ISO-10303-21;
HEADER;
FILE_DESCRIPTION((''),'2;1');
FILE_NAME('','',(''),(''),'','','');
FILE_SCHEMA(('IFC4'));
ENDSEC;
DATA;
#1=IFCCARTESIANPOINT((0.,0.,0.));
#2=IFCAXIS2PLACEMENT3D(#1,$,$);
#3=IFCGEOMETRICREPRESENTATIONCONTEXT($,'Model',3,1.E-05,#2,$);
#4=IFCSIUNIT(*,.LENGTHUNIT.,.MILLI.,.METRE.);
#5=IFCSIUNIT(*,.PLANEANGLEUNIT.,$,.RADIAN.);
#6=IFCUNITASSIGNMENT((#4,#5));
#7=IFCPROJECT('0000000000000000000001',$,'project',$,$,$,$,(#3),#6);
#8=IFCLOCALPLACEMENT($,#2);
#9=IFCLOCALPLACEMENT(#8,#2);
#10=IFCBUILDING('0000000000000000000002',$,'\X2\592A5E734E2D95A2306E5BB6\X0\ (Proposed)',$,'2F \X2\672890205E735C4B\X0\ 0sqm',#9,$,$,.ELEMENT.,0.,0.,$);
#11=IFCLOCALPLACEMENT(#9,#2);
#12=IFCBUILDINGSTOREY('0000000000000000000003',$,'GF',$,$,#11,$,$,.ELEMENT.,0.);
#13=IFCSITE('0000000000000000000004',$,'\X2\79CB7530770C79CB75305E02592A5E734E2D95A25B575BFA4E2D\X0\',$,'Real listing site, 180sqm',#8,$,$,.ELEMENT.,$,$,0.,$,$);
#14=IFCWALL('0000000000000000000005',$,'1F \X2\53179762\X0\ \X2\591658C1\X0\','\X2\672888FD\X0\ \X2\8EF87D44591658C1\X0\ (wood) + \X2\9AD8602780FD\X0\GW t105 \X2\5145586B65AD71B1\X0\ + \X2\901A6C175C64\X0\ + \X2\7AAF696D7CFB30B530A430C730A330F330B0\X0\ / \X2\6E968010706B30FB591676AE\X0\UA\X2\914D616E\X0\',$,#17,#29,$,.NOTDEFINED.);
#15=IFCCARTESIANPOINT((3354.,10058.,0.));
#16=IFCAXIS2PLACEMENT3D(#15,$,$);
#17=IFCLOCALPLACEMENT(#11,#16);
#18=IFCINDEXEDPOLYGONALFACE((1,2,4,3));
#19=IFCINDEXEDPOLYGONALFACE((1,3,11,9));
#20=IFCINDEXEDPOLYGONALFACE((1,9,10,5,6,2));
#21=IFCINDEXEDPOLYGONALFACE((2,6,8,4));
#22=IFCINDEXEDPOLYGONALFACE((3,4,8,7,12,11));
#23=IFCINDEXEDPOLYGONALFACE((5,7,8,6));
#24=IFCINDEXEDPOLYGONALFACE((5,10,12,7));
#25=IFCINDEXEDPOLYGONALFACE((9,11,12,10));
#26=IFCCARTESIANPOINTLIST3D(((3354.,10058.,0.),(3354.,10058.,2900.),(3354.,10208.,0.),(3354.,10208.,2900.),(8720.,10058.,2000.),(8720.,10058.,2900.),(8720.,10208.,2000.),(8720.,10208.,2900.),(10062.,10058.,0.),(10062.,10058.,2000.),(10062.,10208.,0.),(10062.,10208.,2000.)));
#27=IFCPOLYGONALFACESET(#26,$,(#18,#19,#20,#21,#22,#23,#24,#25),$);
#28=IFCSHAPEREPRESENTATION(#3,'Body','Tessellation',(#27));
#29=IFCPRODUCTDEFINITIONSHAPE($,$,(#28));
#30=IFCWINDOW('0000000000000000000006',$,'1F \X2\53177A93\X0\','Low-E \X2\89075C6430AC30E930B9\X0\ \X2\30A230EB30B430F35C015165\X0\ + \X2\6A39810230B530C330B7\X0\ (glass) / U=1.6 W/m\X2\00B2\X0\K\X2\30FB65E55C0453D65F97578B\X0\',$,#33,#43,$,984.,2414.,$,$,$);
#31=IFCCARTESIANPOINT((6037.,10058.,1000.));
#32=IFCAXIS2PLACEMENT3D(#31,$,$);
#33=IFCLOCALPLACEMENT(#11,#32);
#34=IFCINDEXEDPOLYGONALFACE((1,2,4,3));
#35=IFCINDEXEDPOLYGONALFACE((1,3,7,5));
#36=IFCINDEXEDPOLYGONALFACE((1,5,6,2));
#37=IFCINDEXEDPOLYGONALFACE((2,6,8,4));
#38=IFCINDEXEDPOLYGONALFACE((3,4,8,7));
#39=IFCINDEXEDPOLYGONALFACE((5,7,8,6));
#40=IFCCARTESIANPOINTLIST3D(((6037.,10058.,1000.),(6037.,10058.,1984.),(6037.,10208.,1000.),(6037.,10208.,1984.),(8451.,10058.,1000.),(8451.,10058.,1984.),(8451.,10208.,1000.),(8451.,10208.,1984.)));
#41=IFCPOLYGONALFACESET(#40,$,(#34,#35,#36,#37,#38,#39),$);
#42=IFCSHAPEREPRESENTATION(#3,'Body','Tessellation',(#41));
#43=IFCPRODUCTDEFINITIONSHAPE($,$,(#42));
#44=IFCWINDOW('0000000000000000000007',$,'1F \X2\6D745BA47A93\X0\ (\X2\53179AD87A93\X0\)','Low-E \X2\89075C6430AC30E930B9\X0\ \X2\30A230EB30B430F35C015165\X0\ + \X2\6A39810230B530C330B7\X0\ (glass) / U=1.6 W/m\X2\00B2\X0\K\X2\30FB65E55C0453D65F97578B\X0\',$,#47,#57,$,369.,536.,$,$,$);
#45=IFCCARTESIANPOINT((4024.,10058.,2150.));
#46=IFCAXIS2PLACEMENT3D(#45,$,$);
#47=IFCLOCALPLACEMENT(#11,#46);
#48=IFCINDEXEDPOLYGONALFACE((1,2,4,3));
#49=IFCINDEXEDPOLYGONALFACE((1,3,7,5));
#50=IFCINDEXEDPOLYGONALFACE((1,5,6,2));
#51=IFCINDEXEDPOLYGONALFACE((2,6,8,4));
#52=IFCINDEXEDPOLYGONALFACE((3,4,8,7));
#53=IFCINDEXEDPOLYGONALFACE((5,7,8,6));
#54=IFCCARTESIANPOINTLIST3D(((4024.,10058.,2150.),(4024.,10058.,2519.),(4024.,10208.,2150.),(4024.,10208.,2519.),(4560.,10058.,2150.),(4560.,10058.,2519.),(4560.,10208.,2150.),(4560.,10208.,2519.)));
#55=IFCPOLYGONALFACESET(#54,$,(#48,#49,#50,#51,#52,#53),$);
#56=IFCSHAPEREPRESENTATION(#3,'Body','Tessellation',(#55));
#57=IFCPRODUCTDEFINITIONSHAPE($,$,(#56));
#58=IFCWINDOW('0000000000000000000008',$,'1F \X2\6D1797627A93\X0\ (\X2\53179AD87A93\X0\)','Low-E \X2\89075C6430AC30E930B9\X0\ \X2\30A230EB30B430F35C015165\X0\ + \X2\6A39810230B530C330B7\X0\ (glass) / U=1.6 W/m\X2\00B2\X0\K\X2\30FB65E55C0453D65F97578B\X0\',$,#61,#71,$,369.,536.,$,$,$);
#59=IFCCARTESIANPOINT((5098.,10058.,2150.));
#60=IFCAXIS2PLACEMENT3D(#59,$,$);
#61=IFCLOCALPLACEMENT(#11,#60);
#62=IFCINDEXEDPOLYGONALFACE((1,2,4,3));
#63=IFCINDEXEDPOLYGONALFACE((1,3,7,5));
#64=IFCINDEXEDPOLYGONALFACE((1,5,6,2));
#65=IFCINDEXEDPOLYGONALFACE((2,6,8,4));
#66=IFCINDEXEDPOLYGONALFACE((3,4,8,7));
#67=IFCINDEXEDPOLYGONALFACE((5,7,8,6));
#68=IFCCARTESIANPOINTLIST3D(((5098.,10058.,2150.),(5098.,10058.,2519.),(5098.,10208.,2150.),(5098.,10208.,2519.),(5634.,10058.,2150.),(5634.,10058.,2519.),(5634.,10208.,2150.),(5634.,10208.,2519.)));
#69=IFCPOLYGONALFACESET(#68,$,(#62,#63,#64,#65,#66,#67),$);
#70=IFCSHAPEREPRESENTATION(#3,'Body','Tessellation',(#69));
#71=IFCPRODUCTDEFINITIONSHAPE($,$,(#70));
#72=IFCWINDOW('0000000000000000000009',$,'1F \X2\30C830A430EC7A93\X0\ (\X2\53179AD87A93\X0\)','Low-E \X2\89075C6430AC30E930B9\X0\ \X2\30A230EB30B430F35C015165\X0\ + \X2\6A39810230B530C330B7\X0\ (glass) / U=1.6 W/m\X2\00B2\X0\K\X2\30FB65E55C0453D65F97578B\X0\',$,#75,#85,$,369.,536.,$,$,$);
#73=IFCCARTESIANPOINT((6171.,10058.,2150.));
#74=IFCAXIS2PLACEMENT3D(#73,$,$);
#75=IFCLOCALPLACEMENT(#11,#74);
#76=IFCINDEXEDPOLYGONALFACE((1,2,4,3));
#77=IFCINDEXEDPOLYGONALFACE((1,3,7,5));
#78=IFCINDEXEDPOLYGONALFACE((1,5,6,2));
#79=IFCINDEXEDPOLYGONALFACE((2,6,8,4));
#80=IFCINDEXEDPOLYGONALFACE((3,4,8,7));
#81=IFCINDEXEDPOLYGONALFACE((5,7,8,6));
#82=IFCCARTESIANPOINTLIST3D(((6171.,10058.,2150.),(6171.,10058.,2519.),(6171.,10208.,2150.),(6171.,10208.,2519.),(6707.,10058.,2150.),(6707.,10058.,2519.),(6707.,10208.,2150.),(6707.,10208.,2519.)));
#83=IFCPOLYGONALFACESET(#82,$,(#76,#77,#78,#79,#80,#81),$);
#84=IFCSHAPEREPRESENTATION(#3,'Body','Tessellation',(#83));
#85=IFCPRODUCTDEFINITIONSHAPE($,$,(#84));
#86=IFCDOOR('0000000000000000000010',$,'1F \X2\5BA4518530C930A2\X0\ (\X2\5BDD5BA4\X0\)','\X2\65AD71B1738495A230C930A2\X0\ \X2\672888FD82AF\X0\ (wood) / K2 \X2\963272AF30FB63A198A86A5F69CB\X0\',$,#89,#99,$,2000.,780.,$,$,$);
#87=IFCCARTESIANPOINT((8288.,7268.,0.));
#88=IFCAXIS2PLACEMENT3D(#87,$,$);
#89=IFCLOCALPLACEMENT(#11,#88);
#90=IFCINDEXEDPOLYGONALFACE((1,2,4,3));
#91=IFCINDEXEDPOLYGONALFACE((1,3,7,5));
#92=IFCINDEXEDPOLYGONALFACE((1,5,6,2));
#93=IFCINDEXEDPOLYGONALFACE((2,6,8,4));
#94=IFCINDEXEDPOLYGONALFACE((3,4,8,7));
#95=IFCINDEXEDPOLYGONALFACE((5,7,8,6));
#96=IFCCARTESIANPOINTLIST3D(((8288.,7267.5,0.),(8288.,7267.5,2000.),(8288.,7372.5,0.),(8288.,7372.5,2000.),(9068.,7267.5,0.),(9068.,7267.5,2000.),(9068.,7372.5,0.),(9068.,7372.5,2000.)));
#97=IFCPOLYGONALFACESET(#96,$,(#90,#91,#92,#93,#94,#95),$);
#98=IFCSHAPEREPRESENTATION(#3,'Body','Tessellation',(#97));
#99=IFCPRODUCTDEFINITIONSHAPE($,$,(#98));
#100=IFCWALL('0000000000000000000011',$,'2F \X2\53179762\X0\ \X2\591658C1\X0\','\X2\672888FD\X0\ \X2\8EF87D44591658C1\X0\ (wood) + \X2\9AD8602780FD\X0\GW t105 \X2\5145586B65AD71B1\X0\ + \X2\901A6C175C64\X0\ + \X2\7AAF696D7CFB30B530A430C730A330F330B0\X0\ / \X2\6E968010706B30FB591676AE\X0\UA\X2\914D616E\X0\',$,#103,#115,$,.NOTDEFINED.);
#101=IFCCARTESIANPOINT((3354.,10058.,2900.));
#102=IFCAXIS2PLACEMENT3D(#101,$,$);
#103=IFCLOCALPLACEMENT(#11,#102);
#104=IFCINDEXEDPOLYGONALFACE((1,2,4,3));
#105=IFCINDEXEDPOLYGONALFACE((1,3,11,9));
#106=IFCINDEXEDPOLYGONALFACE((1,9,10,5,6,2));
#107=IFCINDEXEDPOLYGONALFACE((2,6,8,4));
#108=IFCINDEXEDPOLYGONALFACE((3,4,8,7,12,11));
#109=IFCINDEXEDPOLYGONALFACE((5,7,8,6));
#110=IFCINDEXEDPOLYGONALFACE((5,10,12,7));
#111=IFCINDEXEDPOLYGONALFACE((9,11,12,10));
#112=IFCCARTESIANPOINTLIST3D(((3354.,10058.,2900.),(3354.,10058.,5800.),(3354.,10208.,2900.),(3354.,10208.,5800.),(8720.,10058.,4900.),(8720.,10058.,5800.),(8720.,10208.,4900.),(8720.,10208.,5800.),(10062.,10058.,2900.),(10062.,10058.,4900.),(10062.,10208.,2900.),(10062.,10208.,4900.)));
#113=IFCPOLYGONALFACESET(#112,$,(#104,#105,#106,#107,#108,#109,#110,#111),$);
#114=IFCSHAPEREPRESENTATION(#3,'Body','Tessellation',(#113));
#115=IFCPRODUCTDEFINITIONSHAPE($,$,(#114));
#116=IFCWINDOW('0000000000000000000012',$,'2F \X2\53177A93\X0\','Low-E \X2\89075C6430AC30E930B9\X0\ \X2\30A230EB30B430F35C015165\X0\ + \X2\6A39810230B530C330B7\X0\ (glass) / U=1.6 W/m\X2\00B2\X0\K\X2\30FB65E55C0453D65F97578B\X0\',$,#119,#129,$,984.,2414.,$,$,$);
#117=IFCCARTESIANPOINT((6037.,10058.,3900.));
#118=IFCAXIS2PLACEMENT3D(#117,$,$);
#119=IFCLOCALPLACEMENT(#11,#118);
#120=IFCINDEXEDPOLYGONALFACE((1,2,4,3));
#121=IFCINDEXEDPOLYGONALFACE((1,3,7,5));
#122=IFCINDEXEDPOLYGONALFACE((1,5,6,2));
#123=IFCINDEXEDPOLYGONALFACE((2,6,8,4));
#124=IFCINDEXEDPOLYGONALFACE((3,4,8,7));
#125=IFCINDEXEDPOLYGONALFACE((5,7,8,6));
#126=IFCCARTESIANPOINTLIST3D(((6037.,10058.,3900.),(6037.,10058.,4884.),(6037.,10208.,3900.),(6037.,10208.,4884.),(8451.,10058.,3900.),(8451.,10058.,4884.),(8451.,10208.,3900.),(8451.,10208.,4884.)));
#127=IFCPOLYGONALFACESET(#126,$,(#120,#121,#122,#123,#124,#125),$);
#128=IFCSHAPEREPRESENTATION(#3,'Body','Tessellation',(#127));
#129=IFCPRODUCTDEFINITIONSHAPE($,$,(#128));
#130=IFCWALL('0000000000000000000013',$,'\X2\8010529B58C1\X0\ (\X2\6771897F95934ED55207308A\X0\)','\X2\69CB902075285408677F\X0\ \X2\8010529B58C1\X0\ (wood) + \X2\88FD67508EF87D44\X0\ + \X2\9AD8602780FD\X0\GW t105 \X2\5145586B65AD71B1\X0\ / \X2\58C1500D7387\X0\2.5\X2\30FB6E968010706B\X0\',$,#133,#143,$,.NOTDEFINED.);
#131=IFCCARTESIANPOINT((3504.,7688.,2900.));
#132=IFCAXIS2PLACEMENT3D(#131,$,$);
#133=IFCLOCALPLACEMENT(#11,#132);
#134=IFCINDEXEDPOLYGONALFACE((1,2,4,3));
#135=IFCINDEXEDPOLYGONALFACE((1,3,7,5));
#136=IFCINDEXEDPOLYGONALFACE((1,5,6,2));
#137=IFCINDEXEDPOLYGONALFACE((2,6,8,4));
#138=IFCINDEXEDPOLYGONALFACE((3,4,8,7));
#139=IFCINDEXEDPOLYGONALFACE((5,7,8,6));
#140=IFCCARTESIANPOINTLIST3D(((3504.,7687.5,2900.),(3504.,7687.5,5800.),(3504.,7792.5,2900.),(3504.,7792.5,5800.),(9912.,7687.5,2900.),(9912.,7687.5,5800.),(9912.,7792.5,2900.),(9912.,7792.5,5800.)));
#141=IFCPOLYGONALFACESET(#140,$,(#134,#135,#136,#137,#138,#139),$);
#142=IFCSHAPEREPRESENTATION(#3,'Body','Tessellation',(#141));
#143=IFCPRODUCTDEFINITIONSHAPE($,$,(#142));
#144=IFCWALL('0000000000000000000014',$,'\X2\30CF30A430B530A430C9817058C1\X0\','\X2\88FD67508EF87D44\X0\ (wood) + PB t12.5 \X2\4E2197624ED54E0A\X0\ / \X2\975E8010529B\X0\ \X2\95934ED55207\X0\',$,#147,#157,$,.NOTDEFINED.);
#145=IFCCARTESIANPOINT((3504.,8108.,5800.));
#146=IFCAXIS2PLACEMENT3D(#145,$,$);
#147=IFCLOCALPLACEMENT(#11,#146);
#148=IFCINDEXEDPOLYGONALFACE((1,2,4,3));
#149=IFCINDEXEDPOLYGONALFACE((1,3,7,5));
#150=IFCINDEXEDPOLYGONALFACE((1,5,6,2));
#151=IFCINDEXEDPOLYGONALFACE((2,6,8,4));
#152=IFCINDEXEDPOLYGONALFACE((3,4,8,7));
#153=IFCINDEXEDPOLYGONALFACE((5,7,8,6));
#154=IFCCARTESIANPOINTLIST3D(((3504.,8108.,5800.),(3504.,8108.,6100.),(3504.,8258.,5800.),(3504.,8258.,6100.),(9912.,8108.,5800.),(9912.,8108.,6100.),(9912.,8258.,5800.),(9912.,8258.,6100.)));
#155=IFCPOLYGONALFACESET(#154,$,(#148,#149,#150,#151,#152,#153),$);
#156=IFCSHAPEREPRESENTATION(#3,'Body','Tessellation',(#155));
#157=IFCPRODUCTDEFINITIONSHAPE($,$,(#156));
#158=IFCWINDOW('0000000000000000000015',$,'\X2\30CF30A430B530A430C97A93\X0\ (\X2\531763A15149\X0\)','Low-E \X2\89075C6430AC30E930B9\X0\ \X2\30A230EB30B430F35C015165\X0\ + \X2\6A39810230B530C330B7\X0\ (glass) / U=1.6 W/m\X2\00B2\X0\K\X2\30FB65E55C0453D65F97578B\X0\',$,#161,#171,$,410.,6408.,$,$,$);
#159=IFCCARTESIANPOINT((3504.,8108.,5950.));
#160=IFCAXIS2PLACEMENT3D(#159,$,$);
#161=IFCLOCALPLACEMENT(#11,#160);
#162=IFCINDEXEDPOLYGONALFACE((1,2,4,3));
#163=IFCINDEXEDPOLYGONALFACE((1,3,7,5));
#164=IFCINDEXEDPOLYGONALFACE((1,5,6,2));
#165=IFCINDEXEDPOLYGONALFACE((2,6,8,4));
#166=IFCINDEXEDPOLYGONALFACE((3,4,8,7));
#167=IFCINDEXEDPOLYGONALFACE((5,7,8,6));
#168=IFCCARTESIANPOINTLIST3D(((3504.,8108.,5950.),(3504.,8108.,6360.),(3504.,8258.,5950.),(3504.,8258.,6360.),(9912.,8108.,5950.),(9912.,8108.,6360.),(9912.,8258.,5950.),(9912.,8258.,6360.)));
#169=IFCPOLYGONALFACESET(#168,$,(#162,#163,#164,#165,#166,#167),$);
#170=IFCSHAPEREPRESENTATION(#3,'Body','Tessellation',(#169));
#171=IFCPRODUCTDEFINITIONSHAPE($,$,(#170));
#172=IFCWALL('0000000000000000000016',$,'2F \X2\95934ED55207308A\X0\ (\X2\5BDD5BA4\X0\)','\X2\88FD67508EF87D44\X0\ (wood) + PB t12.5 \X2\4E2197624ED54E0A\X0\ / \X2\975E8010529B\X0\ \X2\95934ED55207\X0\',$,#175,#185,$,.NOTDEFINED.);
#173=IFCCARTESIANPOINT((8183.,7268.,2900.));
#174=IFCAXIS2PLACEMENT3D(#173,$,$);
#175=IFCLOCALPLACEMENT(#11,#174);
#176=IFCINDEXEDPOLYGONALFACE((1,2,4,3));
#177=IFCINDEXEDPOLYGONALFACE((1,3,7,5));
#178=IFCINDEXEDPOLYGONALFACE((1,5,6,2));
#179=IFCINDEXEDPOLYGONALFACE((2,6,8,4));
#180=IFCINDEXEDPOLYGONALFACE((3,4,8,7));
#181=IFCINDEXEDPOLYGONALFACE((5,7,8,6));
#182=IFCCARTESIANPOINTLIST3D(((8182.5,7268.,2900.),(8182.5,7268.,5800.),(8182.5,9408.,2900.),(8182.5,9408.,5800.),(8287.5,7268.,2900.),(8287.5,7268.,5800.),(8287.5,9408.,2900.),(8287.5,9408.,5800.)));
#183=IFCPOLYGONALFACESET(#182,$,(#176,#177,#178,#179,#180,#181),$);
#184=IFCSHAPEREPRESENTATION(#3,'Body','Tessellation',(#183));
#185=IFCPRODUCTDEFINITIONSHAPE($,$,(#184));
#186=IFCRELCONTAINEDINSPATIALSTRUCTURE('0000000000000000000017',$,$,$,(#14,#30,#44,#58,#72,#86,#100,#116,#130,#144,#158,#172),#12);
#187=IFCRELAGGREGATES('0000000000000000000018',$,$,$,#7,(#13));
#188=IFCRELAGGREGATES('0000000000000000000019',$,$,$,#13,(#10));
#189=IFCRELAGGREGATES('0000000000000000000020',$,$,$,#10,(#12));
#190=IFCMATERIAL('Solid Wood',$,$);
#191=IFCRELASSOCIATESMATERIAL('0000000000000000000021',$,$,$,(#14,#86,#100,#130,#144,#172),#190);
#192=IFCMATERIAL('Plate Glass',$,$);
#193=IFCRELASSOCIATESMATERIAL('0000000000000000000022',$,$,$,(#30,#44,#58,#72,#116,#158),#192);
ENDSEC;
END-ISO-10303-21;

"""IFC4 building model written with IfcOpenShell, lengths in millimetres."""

from ifc_helpers import new_model, si_unit, frame, frame_2d, origin, place, context, project, spatial, rectangle, extrude, material, element, fill, save


model = new_model("IFC4")

# Units and contexts
model_context = context("Model", 3, precision=1e-05, world=origin())
ifc_project = project(units=[si_unit("LENGTHUNIT", "METRE", prefix="MILLI"), si_unit("PLANEANGLEUNIT", "RADIAN")], contexts=[model_context])

# Site, building, storey
site_placement = place(None, origin())
site = spatial("IfcSite", under=ifc_project, at=site_placement, Name="秋田県秋田市太平中関字寺中", ObjectType="Real listing site, 180sqm", CompositionType="ELEMENT", RefElevation=0.0)
building_placement = place(site_placement, origin())
building = spatial("IfcBuilding", under=site, at=building_placement, Name="太平中関の家 (Proposed)", ObjectType="2F 木造平屋 0sqm", CompositionType="ELEMENT", ElevationOfRefHeight=0.0, ElevationOfTerrain=0.0)
storey_placement = place(building_placement, origin())
storey = spatial("IfcBuildingStorey", under=building, at=storey_placement, Name="GF", CompositionType="ELEMENT", Elevation=0.0)

# Wall, openings, windows
ifc_material_1 = material(Name="Solid Wood")
wall_1_placement = place(storey_placement, frame((3354.0, 10058.0, 0.0)))
wall_1 = element("IfcWall", 1, at=wall_1_placement, inside=storey, material=ifc_material_1, Name="1F 北面 外壁", Description="木製 軸組外壁 (wood) + 高性能GW t105 充填断熱 + 通気層 + 窯業系サイディング / 準耐火・外皮UA配慮", PredefinedType="NOTDEFINED", context=model_context, shape_type="SweptSolid", body=[
    extrude(rectangle(XDim=6708.0, YDim=150.0, at=frame_2d((3354.0, 75.0))), frame((3354.0, 10058.0, 0.0)), (0.0, 0.0, 1.0), 2900.0),
])
opening_1_placement = place(storey_placement, frame((6037.0, 10058.0, 1000.0)))
opening_1 = element("IfcOpeningElement", 2, at=opening_1_placement, cuts=wall_1, PredefinedType="NOTDEFINED", context=model_context, shape_type="SweptSolid", body=[
    extrude(rectangle(XDim=2414.0, YDim=150.0, at=frame_2d((1207.0, 75.0))), frame((6037.0, 10058.0, 1000.0)), (0.0, 0.0, 1.0), 984.0),
])
opening_2_placement = place(storey_placement, frame((4024.0, 10058.0, 2150.0)))
opening_2 = element("IfcOpeningElement", 3, at=opening_2_placement, cuts=wall_1, PredefinedType="NOTDEFINED", context=model_context, shape_type="SweptSolid", body=[
    extrude(rectangle(XDim=536.0, YDim=150.0, at=frame_2d((268.0, 75.0))), frame((4024.0, 10058.0, 2150.0)), (0.0, 0.0, 1.0), 369.0),
])
opening_3_placement = place(storey_placement, frame((5098.0, 10058.0, 2150.0)))
opening_3 = element("IfcOpeningElement", 4, at=opening_3_placement, cuts=wall_1, PredefinedType="NOTDEFINED", context=model_context, shape_type="SweptSolid", body=[
    extrude(rectangle(XDim=536.0, YDim=150.0, at=frame_2d((268.0, 75.0))), frame((5098.0, 10058.0, 2150.0)), (0.0, 0.0, 1.0), 369.0),
])
opening_4_placement = place(storey_placement, frame((6171.0, 10058.0, 2150.0)))
opening_4 = element("IfcOpeningElement", 5, at=opening_4_placement, cuts=wall_1, PredefinedType="NOTDEFINED", context=model_context, shape_type="SweptSolid", body=[
    extrude(rectangle(XDim=536.0, YDim=150.0, at=frame_2d((268.0, 75.0))), frame((6171.0, 10058.0, 2150.0)), (0.0, 0.0, 1.0), 369.0),
])
ifc_material_2 = material(Name="Plate Glass")
window_1_placement = place(storey_placement, frame((6037.0, 10058.0, 1000.0)))
window_1 = element("IfcWindow", 6, at=window_1_placement, inside=storey, material=ifc_material_2, Name="1F 北窓", Description="Low-E 複層ガラス アルゴン封入 + 樹脂サッシ (glass) / U=1.6 W/m²K・日射取得型", OverallHeight=984.0, OverallWidth=2414.0, context=model_context, shape_type="SweptSolid", body=[
    extrude(rectangle(XDim=2414.0, YDim=150.0, at=frame_2d((1207.0, 75.0))), frame((6037.0, 10058.0, 1000.0)), (0.0, 0.0, 1.0), 984.0),
])
fill(opening_1, window_1)
window_2_placement = place(storey_placement, frame((4024.0, 10058.0, 2150.0)))
window_2 = element("IfcWindow", 7, at=window_2_placement, inside=storey, material=ifc_material_2, Name="1F 浴室窓 (北高窓)", Description="Low-E 複層ガラス アルゴン封入 + 樹脂サッシ (glass) / U=1.6 W/m²K・日射取得型", OverallHeight=369.0, OverallWidth=536.0, context=model_context, shape_type="SweptSolid", body=[
    extrude(rectangle(XDim=536.0, YDim=150.0, at=frame_2d((268.0, 75.0))), frame((4024.0, 10058.0, 2150.0)), (0.0, 0.0, 1.0), 369.0),
])
fill(opening_2, window_2)
window_3_placement = place(storey_placement, frame((5098.0, 10058.0, 2150.0)))
window_3 = element("IfcWindow", 8, at=window_3_placement, inside=storey, material=ifc_material_2, Name="1F 洗面窓 (北高窓)", Description="Low-E 複層ガラス アルゴン封入 + 樹脂サッシ (glass) / U=1.6 W/m²K・日射取得型", OverallHeight=369.0, OverallWidth=536.0, context=model_context, shape_type="SweptSolid", body=[
    extrude(rectangle(XDim=536.0, YDim=150.0, at=frame_2d((268.0, 75.0))), frame((5098.0, 10058.0, 2150.0)), (0.0, 0.0, 1.0), 369.0),
])
fill(opening_3, window_3)
window_4_placement = place(storey_placement, frame((6171.0, 10058.0, 2150.0)))
window_4 = element("IfcWindow", 9, at=window_4_placement, inside=storey, material=ifc_material_2, Name="1F トイレ窓 (北高窓)", Description="Low-E 複層ガラス アルゴン封入 + 樹脂サッシ (glass) / U=1.6 W/m²K・日射取得型", OverallHeight=369.0, OverallWidth=536.0, context=model_context, shape_type="SweptSolid", body=[
    extrude(rectangle(XDim=536.0, YDim=150.0, at=frame_2d((268.0, 75.0))), frame((6171.0, 10058.0, 2150.0)), (0.0, 0.0, 1.0), 369.0),
])
fill(opening_4, window_4)

# Door
door_1_placement = place(storey_placement, frame((8288.0, 7268.0, 0.0)))
element("IfcDoor", 10, at=door_1_placement, inside=storey, material=ifc_material_1, Name="1F 室内ドア (寝室)", Description="断熱玄関ドア 木製芯 (wood) / K2 防犯・採風機構", OverallHeight=2000.0, OverallWidth=780.0, context=model_context, shape_type="SweptSolid", body=[
    extrude(rectangle(XDim=780.0, YDim=105.0, at=frame_2d((390.0, 52.0))), frame((8288.0, 7268.0, 0.0)), (0.0, 0.0, 1.0), 2000.0),
])

# Wall, opening, window
wall_2_placement = place(storey_placement, frame((3354.0, 10058.0, 2900.0)))
wall_2 = element("IfcWall", 11, at=wall_2_placement, inside=storey, material=ifc_material_1, Name="2F 北面 外壁", Description="木製 軸組外壁 (wood) + 高性能GW t105 充填断熱 + 通気層 + 窯業系サイディング / 準耐火・外皮UA配慮", PredefinedType="NOTDEFINED", context=model_context, shape_type="SweptSolid", body=[
    extrude(rectangle(XDim=6708.0, YDim=150.0, at=frame_2d((3354.0, 75.0))), frame((3354.0, 10058.0, 2900.0)), (0.0, 0.0, 1.0), 2900.0),
])
opening_5_placement = place(storey_placement, frame((6037.0, 10058.0, 3900.0)))
opening_5 = element("IfcOpeningElement", 12, at=opening_5_placement, cuts=wall_2, PredefinedType="NOTDEFINED", context=model_context, shape_type="SweptSolid", body=[
    extrude(rectangle(XDim=2414.0, YDim=150.0, at=frame_2d((1207.0, 75.0))), frame((6037.0, 10058.0, 3900.0)), (0.0, 0.0, 1.0), 984.0),
])
window_5_placement = place(storey_placement, frame((6037.0, 10058.0, 3900.0)))
window_5 = element("IfcWindow", 13, at=window_5_placement, inside=storey, material=ifc_material_2, Name="2F 北窓", Description="Low-E 複層ガラス アルゴン封入 + 樹脂サッシ (glass) / U=1.6 W/m²K・日射取得型", OverallHeight=984.0, OverallWidth=2414.0, context=model_context, shape_type="SweptSolid", body=[
    extrude(rectangle(XDim=2414.0, YDim=150.0, at=frame_2d((1207.0, 75.0))), frame((6037.0, 10058.0, 3900.0)), (0.0, 0.0, 1.0), 984.0),
])
fill(opening_5, window_5)

# Wall
wall_3_placement = place(storey_placement, frame((3504.0, 7688.0, 2900.0)))
element("IfcWall", 14, at=wall_3_placement, inside=storey, material=ifc_material_1, Name="耐力壁 (東西間仕切り)", Description="構造用合板 耐力壁 (wood) + 製材軸組 + 高性能GW t105 充填断熱 / 壁倍率2.5・準耐火", PredefinedType="NOTDEFINED", context=model_context, shape_type="SweptSolid", body=[
    extrude(rectangle(XDim=6408.0, YDim=105.0, at=frame_2d((3204.0, 52.0))), frame((3504.0, 7688.0, 2900.0)), (0.0, 0.0, 1.0), 2900.0),
])

# Wall, opening, window
wall_4_placement = place(storey_placement, frame((3504.0, 8108.0, 5800.0)))
wall_4 = element("IfcWall", 15, at=wall_4_placement, inside=storey, material=ifc_material_1, Name="ハイサイド腰壁", Description="製材軸組 (wood) + PB t12.5 両面仕上 / 非耐力 間仕切", PredefinedType="NOTDEFINED", context=model_context, shape_type="SweptSolid", body=[
    extrude(rectangle(XDim=6408.0, YDim=150.0, at=frame_2d((3204.0, 75.0))), frame((3504.0, 8108.0, 5800.0)), (0.0, 0.0, 1.0), 700.0),
])
opening_6_placement = place(storey_placement, frame((3504.0, 8108.0, 5950.0)))
opening_6 = element("IfcOpeningElement", 16, at=opening_6_placement, cuts=wall_4, PredefinedType="NOTDEFINED", context=model_context, shape_type="SweptSolid", body=[
    extrude(rectangle(XDim=6408.0, YDim=150.0, at=frame_2d((3204.0, 75.0))), frame((3504.0, 8108.0, 5950.0)), (0.0, 0.0, 1.0), 410.0),
])
window_6_placement = place(storey_placement, frame((3504.0, 8108.0, 5950.0)))
window_6 = element("IfcWindow", 17, at=window_6_placement, inside=storey, material=ifc_material_2, Name="ハイサイド窓 (北採光)", Description="Low-E 複層ガラス アルゴン封入 + 樹脂サッシ (glass) / U=1.6 W/m²K・日射取得型", OverallHeight=410.0, OverallWidth=6408.0, context=model_context, shape_type="SweptSolid", body=[
    extrude(rectangle(XDim=6408.0, YDim=150.0, at=frame_2d((3204.0, 75.0))), frame((3504.0, 8108.0, 5950.0)), (0.0, 0.0, 1.0), 410.0),
])
fill(opening_6, window_6)

# Wall
wall_5_placement = place(storey_placement, frame((8183.0, 7268.0, 2900.0)))
element("IfcWall", 18, at=wall_5_placement, inside=storey, material=ifc_material_1, Name="2F 間仕切り (寝室)", Description="製材軸組 (wood) + PB t12.5 両面仕上 / 非耐力 間仕切", PredefinedType="NOTDEFINED", context=model_context, shape_type="SweptSolid", body=[
    extrude(rectangle(XDim=105.0, YDim=2140.0, at=frame_2d((52.0, 1070.0))), frame((8183.0, 7268.0, 2900.0)), (0.0, 0.0, 1.0), 2900.0),
])

save(model, "model.ifc")
